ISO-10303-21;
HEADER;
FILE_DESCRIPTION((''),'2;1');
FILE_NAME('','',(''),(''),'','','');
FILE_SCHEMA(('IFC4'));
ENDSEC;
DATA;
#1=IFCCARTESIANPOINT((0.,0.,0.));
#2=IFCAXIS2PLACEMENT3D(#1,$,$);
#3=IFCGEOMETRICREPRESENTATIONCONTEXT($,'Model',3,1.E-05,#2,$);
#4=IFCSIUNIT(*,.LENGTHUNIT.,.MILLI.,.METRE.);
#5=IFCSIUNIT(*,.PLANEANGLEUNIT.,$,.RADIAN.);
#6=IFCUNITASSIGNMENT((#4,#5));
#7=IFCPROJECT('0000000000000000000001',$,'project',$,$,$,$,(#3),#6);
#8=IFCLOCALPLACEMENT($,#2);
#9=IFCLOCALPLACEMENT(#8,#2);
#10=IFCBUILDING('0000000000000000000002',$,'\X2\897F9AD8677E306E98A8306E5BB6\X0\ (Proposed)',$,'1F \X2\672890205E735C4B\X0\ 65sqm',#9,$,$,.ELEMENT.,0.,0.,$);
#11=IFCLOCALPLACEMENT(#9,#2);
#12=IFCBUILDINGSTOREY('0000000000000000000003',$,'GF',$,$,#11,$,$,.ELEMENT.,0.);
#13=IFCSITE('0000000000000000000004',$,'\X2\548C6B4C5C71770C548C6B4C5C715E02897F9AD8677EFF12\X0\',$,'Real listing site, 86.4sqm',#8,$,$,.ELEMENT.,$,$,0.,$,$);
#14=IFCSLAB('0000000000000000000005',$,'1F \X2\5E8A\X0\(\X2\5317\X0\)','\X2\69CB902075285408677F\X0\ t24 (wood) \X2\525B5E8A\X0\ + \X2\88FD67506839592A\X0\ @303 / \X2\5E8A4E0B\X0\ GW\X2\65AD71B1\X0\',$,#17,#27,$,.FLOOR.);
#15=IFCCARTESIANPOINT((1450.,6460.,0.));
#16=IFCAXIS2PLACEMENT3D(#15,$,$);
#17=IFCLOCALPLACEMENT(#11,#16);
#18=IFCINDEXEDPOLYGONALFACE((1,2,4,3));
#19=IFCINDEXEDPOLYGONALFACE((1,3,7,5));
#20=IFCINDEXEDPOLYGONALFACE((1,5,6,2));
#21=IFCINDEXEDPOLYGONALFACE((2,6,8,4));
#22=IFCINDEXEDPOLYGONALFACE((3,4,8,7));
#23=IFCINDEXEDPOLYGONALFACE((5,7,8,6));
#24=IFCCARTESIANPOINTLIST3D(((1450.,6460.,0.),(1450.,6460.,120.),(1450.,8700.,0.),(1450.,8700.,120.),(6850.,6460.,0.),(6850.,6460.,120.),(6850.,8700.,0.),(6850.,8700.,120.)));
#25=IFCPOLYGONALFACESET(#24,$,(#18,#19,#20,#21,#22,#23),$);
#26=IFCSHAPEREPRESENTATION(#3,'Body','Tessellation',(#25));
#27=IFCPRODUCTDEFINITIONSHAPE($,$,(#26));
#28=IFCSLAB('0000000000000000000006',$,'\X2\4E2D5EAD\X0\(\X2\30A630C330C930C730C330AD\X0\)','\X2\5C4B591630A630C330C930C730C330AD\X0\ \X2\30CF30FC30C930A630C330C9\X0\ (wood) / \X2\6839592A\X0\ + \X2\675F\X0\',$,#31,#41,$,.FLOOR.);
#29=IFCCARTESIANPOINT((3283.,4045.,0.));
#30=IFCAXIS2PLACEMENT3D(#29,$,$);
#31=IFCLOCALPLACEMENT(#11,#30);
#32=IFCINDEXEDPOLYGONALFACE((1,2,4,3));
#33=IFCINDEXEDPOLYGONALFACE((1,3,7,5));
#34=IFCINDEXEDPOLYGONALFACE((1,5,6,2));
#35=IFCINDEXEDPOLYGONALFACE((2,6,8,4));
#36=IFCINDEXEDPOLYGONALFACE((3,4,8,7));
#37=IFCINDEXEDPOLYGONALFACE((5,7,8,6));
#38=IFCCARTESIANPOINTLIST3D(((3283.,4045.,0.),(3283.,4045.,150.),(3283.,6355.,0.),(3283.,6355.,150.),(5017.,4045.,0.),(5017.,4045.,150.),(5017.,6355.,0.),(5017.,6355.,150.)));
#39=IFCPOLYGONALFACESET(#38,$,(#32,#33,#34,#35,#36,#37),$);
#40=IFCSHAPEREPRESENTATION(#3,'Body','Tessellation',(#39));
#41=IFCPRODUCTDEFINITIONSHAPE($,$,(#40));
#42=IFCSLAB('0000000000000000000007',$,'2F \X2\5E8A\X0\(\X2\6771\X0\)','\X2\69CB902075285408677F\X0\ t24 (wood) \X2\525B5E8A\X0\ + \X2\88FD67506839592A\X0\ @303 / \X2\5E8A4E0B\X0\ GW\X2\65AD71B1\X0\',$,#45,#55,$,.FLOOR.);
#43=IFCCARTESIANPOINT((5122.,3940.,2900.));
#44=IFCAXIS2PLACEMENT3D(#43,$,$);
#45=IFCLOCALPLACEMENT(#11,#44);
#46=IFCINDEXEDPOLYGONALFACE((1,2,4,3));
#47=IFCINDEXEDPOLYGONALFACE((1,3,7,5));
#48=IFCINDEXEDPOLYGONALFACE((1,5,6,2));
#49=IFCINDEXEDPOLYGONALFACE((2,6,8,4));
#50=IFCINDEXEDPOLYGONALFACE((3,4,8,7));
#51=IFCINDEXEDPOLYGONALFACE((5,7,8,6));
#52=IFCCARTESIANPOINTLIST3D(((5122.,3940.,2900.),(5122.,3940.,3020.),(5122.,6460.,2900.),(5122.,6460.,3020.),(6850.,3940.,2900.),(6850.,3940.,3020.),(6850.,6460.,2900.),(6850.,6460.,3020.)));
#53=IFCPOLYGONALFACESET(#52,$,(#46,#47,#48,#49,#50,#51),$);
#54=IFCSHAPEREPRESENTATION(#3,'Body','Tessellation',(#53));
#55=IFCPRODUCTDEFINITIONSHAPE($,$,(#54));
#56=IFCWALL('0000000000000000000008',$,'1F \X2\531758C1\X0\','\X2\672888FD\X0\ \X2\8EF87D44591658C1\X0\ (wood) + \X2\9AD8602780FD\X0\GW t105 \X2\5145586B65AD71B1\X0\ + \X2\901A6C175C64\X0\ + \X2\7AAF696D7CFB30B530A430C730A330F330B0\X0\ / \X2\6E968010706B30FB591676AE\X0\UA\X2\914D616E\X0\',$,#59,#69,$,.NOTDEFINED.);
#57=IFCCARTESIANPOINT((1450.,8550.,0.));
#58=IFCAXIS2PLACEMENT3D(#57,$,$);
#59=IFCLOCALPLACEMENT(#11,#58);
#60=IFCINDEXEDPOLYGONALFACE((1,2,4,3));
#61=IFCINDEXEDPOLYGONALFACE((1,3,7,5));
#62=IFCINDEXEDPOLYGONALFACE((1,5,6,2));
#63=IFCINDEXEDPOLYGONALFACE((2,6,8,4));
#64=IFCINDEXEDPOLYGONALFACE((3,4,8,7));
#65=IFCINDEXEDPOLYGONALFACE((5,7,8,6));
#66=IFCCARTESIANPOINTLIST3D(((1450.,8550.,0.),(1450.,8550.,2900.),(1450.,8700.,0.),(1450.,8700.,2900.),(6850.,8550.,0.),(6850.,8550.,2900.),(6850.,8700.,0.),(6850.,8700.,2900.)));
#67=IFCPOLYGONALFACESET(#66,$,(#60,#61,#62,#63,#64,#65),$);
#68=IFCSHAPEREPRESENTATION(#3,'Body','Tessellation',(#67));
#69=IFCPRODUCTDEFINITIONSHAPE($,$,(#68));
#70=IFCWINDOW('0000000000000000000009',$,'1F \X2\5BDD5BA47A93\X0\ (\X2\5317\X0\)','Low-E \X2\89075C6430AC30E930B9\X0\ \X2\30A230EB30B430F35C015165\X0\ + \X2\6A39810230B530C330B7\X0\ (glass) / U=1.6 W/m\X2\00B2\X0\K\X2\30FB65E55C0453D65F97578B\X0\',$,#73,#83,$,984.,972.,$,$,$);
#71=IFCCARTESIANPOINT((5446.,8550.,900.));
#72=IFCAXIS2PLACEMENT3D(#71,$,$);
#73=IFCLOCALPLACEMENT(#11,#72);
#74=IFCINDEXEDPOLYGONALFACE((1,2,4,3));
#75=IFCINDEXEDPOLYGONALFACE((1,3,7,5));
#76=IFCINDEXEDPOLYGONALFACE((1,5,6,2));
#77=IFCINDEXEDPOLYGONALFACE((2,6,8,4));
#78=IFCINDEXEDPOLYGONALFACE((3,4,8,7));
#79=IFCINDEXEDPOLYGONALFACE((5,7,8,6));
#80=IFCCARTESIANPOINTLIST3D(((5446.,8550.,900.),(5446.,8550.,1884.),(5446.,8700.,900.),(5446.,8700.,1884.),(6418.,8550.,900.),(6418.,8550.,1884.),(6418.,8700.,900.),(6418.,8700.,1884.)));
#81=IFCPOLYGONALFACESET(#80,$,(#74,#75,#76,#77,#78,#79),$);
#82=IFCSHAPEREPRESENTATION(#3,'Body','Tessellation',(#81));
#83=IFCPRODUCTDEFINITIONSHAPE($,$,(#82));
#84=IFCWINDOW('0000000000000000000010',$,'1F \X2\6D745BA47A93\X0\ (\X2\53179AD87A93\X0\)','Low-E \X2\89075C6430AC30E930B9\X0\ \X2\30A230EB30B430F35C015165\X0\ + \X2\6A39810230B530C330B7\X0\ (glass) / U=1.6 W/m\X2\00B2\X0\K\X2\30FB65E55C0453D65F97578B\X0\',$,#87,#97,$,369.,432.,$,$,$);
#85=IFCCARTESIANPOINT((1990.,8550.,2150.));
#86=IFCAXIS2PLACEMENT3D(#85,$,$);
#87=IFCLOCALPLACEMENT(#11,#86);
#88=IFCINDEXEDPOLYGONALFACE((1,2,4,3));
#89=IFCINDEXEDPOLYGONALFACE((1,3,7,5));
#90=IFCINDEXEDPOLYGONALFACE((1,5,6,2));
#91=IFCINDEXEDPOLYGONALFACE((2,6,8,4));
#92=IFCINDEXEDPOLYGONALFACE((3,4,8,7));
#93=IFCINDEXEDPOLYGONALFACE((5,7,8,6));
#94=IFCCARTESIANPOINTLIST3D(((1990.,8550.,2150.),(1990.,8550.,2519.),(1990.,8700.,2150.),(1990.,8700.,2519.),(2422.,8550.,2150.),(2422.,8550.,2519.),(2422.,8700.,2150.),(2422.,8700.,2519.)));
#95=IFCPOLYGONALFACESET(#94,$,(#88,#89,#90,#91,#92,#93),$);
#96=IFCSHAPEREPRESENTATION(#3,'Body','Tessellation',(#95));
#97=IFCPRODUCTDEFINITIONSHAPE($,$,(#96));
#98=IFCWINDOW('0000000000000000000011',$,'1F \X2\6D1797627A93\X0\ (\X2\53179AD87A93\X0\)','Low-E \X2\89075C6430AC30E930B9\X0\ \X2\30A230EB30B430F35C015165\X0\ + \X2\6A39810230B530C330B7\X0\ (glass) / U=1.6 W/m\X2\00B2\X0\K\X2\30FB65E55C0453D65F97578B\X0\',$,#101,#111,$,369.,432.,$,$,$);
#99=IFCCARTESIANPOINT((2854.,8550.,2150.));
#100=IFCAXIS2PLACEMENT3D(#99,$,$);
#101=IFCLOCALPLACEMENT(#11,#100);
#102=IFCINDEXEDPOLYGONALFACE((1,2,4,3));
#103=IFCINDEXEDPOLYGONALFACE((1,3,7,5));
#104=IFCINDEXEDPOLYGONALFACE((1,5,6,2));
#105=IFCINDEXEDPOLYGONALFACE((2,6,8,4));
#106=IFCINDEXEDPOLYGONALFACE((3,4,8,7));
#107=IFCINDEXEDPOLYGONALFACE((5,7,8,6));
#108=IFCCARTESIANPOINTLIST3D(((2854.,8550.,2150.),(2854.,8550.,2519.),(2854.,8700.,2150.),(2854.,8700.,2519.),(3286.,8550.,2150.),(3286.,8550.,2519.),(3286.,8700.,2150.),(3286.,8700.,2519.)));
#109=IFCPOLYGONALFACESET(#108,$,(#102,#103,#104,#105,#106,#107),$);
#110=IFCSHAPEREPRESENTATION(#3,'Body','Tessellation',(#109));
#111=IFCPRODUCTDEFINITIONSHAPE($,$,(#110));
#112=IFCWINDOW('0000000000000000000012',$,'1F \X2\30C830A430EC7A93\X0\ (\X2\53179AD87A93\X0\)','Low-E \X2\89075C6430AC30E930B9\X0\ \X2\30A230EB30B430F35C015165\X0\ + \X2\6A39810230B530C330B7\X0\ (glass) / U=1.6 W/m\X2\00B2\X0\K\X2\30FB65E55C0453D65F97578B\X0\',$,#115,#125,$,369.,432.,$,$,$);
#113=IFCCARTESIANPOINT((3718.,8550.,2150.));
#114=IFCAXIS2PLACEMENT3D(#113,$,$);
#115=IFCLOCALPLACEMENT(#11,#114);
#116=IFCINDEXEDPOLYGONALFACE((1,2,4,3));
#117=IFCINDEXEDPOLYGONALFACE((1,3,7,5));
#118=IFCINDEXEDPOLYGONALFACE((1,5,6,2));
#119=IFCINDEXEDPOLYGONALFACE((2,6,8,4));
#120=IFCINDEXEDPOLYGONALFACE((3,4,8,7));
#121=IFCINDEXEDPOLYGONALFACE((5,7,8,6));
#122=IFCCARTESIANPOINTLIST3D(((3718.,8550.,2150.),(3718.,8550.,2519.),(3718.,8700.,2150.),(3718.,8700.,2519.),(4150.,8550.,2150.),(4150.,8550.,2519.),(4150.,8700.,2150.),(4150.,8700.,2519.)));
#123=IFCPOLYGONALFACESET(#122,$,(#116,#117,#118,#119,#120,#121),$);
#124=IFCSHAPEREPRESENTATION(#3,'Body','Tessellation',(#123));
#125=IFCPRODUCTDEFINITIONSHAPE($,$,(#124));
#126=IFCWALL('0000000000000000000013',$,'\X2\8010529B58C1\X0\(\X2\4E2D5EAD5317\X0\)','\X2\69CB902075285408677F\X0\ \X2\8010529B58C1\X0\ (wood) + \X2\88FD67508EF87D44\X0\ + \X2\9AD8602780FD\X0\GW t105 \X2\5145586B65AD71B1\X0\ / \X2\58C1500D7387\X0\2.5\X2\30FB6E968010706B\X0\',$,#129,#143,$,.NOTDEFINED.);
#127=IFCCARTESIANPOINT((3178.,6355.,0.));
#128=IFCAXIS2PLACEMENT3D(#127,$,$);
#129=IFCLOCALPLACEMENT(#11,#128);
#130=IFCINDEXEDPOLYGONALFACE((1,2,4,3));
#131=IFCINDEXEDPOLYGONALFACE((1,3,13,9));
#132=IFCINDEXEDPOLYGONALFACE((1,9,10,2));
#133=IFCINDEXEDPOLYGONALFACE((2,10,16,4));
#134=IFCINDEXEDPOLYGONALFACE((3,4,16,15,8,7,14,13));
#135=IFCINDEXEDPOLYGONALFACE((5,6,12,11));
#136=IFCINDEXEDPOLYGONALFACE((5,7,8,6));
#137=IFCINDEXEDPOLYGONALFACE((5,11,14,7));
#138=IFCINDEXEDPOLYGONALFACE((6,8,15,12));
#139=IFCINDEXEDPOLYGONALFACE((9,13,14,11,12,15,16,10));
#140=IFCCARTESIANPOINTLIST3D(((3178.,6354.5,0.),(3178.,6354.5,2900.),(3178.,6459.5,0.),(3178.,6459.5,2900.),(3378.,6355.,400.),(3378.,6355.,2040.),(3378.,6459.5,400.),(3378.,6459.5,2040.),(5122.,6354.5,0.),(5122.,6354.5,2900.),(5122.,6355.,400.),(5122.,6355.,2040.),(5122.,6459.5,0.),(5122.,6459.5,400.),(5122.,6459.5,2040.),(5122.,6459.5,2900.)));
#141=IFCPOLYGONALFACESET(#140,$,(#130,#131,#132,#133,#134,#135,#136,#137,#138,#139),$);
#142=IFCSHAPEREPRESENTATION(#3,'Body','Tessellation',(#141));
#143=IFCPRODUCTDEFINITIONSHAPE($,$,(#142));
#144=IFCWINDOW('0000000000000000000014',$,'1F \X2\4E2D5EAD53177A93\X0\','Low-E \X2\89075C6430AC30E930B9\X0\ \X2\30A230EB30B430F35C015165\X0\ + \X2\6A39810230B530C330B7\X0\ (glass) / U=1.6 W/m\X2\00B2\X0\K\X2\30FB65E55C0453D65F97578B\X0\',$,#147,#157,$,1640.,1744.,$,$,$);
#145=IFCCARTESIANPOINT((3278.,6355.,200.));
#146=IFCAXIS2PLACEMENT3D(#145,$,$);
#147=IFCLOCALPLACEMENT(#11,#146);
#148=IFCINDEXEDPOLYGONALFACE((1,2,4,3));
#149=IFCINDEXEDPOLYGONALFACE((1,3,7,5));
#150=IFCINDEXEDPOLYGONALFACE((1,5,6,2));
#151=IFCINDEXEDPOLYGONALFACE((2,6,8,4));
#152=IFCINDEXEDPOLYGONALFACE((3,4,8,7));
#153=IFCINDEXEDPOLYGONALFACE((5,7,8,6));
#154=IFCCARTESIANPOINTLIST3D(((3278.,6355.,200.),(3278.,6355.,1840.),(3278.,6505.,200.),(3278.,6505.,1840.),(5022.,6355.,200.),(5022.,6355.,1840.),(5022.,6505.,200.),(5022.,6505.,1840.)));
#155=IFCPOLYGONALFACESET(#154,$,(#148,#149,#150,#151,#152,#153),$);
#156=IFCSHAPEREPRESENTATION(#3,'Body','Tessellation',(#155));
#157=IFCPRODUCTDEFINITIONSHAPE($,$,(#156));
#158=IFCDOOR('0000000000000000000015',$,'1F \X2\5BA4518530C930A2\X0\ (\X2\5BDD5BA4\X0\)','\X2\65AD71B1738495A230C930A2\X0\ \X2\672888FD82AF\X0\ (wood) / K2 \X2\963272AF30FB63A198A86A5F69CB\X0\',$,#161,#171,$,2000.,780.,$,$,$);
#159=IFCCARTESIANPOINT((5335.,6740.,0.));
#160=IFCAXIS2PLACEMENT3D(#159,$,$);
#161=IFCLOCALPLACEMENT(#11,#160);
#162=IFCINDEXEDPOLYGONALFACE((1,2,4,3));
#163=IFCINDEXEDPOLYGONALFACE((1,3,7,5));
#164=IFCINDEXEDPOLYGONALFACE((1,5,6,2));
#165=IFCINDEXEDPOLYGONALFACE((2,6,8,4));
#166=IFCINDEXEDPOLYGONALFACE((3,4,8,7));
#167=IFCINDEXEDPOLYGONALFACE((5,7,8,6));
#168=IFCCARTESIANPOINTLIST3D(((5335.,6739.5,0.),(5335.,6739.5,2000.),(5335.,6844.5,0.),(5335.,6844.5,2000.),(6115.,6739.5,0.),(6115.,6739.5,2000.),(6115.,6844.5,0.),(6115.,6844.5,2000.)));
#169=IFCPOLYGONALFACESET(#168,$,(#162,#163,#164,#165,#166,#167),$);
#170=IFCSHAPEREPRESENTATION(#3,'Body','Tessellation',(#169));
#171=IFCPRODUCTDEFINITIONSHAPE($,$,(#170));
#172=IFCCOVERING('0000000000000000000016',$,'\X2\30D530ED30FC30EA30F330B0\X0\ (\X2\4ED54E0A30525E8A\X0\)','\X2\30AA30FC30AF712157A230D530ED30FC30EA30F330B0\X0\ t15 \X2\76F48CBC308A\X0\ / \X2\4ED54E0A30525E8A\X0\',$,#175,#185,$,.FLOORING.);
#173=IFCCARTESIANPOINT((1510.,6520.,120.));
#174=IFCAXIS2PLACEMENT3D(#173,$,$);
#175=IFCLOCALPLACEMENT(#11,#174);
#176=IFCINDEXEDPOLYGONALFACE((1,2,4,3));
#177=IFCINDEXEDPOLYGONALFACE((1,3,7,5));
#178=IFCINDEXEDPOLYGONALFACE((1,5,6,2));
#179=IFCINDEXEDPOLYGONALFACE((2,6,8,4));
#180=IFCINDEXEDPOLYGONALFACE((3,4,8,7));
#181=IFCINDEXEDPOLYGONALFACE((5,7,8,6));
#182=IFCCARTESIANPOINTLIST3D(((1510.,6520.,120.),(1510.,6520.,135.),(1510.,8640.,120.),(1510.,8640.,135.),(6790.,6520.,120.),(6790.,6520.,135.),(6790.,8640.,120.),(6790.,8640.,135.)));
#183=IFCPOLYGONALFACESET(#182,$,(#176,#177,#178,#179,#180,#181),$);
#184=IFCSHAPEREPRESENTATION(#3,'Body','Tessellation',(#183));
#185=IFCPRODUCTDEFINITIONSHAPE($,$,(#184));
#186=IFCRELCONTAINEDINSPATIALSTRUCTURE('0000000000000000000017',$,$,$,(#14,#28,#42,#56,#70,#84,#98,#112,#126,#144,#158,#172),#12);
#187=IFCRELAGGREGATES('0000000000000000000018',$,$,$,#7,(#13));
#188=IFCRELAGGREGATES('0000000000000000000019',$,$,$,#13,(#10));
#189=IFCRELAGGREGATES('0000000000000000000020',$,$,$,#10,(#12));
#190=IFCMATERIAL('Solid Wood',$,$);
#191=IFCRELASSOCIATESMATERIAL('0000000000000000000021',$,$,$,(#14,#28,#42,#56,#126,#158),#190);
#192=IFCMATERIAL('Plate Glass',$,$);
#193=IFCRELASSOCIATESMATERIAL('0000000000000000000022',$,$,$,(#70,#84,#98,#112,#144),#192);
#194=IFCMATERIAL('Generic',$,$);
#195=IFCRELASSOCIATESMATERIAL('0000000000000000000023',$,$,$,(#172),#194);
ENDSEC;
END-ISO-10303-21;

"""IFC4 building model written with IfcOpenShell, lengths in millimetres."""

from ifc_helpers import new_model, si_unit, frame, frame_2d, origin, place, context, project, spatial, rectangle, extrude, material, element, fill, save


model = new_model("IFC4")

# Units and contexts
model_context = context("Model", 3, precision=1e-05, world=origin())
ifc_project = project(units=[si_unit("LENGTHUNIT", "METRE", prefix="MILLI"), si_unit("PLANEANGLEUNIT", "RADIAN")], contexts=[model_context])

# Site, building, storey
site_placement = place(None, origin())
site = spatial("IfcSite", under=ifc_project, at=site_placement, Name="和歌山県和歌山市西高松２", ObjectType="Real listing site, 86.4sqm", CompositionType="ELEMENT", RefElevation=0.0)
building_placement = place(site_placement, origin())
building = spatial("IfcBuilding", under=site, at=building_placement, Name="西高松の風の家 (Proposed)", ObjectType="1F 木造平屋 65sqm", CompositionType="ELEMENT", ElevationOfRefHeight=0.0, ElevationOfTerrain=0.0)
storey_placement = place(building_placement, origin())
storey = spatial("IfcBuildingStorey", under=building, at=storey_placement, Name="GF", CompositionType="ELEMENT", Elevation=0.0)

# Slabs
ifc_material_1 = material(Name="Solid Wood")
slab_1_placement = place(storey_placement, frame((1450.0, 6460.0, 0.0)))
element("IfcSlab", 1, at=slab_1_placement, inside=storey, material=ifc_material_1, Name="1F 床(北)", Description="構造用合板 t24 (wood) 剛床 + 製材根太 @303 / 床下 GW断熱", PredefinedType="FLOOR", context=model_context, shape_type="SweptSolid", body=[
    extrude(rectangle(XDim=5400.0, YDim=2240.0, at=frame_2d((2700.0, 1120.0))), frame((1450.0, 6460.0, 0.0)), (0.0, 0.0, 1.0), 120.0),
])
slab_2_placement = place(storey_placement, frame((3283.0, 4045.0, 0.0)))
element("IfcSlab", 2, at=slab_2_placement, inside=storey, material=ifc_material_1, Name="中庭(ウッドデッキ)", Description="屋外ウッドデッキ ハードウッド (wood) / 根太 + 束", PredefinedType="FLOOR", context=model_context, shape_type="SweptSolid", body=[
    extrude(rectangle(XDim=1734.0, YDim=2310.0, at=frame_2d((867.0, 1155.0))), frame((3283.0, 4045.0, 0.0)), (0.0, 0.0, 1.0), 150.0),
])
slab_3_placement = place(storey_placement, frame((5122.0, 3940.0, 2900.0)))
element("IfcSlab", 3, at=slab_3_placement, inside=storey, material=ifc_material_1, Name="2F 床(東)", Description="構造用合板 t24 (wood) 剛床 + 製材根太 @303 / 床下 GW断熱", PredefinedType="FLOOR", context=model_context, shape_type="SweptSolid", body=[
    extrude(rectangle(XDim=1728.0, YDim=2520.0, at=frame_2d((864.0, 1260.0))), frame((5122.0, 3940.0, 2900.0)), (0.0, 0.0, 1.0), 120.0),
])

# Wall, openings, windows
wall_1_placement = place(storey_placement, frame((1450.0, 8550.0, 0.0)))
wall_1 = element("IfcWall", 4, at=wall_1_placement, inside=storey, material=ifc_material_1, Name="1F 北壁", Description="木製 軸組外壁 (wood) + 高性能GW t105 充填断熱 + 通気層 + 窯業系サイディング / 準耐火・外皮UA配慮", PredefinedType="NOTDEFINED", context=model_context, shape_type="SweptSolid", body=[
    extrude(rectangle(XDim=5400.0, YDim=150.0, at=frame_2d((2700.0, 75.0))), frame((1450.0, 8550.0, 0.0)), (0.0, 0.0, 1.0), 2900.0),
])
opening_1_placement = place(storey_placement, frame((5446.0, 8550.0, 900.0)))
opening_1 = element("IfcOpeningElement", 5, at=opening_1_placement, cuts=wall_1, PredefinedType="NOTDEFINED", context=model_context, shape_type="SweptSolid", body=[
    extrude(rectangle(XDim=972.0, YDim=150.0, at=frame_2d((486.0, 75.0))), frame((5446.0, 8550.0, 900.0)), (0.0, 0.0, 1.0), 984.0),
])
opening_2_placement = place(storey_placement, frame((1990.0, 8550.0, 2150.0)))
opening_2 = element("IfcOpeningElement", 6, at=opening_2_placement, cuts=wall_1, PredefinedType="NOTDEFINED", context=model_context, shape_type="SweptSolid", body=[
    extrude(rectangle(XDim=432.0, YDim=150.0, at=frame_2d((216.0, 75.0))), frame((1990.0, 8550.0, 2150.0)), (0.0, 0.0, 1.0), 369.0),
])
opening_3_placement = place(storey_placement, frame((2854.0, 8550.0, 2150.0)))
opening_3 = element("IfcOpeningElement", 7, at=opening_3_placement, cuts=wall_1, PredefinedType="NOTDEFINED", context=model_context, shape_type="SweptSolid", body=[
    extrude(rectangle(XDim=432.0, YDim=150.0, at=frame_2d((216.0, 75.0))), frame((2854.0, 8550.0, 2150.0)), (0.0, 0.0, 1.0), 369.0),
])
opening_4_placement = place(storey_placement, frame((3718.0, 8550.0, 2150.0)))
opening_4 = element("IfcOpeningElement", 8, at=opening_4_placement, cuts=wall_1, PredefinedType="NOTDEFINED", context=model_context, shape_type="SweptSolid", body=[
    extrude(rectangle(XDim=432.0, YDim=150.0, at=frame_2d((216.0, 75.0))), frame((3718.0, 8550.0, 2150.0)), (0.0, 0.0, 1.0), 369.0),
])
ifc_material_2 = material(Name="Plate Glass")
window_1_placement = place(storey_placement, frame((5446.0, 8550.0, 900.0)))
window_1 = element("IfcWindow", 9, at=window_1_placement, inside=storey, material=ifc_material_2, Name="1F 寝室窓 (北)", Description="Low-E 複層ガラス アルゴン封入 + 樹脂サッシ (glass) / U=1.6 W/m²K・日射取得型", OverallHeight=984.0, OverallWidth=972.0, context=model_context, shape_type="SweptSolid", body=[
    extrude(rectangle(XDim=972.0, YDim=150.0, at=frame_2d((486.0, 75.0))), frame((5446.0, 8550.0, 900.0)), (0.0, 0.0, 1.0), 984.0),
])
fill(opening_1, window_1)
window_2_placement = place(storey_placement, frame((1990.0, 8550.0, 2150.0)))
window_2 = element("IfcWindow", 10, at=window_2_placement, inside=storey, material=ifc_material_2, Name="1F 浴室窓 (北高窓)", Description="Low-E 複層ガラス アルゴン封入 + 樹脂サッシ (glass) / U=1.6 W/m²K・日射取得型", OverallHeight=369.0, OverallWidth=432.0, context=model_context, shape_type="SweptSolid", body=[
    extrude(rectangle(XDim=432.0, YDim=150.0, at=frame_2d((216.0, 75.0))), frame((1990.0, 8550.0, 2150.0)), (0.0, 0.0, 1.0), 369.0),
])
fill(opening_2, window_2)
window_3_placement = place(storey_placement, frame((2854.0, 8550.0, 2150.0)))
window_3 = element("IfcWindow", 11, at=window_3_placement, inside=storey, material=ifc_material_2, Name="1F 洗面窓 (北高窓)", Description="Low-E 複層ガラス アルゴン封入 + 樹脂サッシ (glass) / U=1.6 W/m²K・日射取得型", OverallHeight=369.0, OverallWidth=432.0, context=model_context, shape_type="SweptSolid", body=[
    extrude(rectangle(XDim=432.0, YDim=150.0, at=frame_2d((216.0, 75.0))), frame((2854.0, 8550.0, 2150.0)), (0.0, 0.0, 1.0), 369.0),
])
fill(opening_3, window_3)
window_4_placement = place(storey_placement, frame((3718.0, 8550.0, 2150.0)))
window_4 = element("IfcWindow", 12, at=window_4_placement, inside=storey, material=ifc_material_2, Name="1F トイレ窓 (北高窓)", Description="Low-E 複層ガラス アルゴン封入 + 樹脂サッシ (glass) / U=1.6 W/m²K・日射取得型", OverallHeight=369.0, OverallWidth=432.0, context=model_context, shape_type="SweptSolid", body=[
    extrude(rectangle(XDim=432.0, YDim=150.0, at=frame_2d((216.0, 75.0))), frame((3718.0, 8550.0, 2150.0)), (0.0, 0.0, 1.0), 369.0),
])
fill(opening_4, window_4)

# Wall, opening, window
wall_2_placement = place(storey_placement, frame((3178.0, 6355.0, 0.0)))
wall_2 = element("IfcWall", 13, at=wall_2_placement, inside=storey, material=ifc_material_1, Name="耐力壁(中庭北)", Description="構造用合板 耐力壁 (wood) + 製材軸組 + 高性能GW t105 充填断熱 / 壁倍率2.5・準耐火", PredefinedType="NOTDEFINED", context=model_context, shape_type="SweptSolid", body=[
    extrude(rectangle(XDim=1944.0, YDim=105.0, at=frame_2d((972.0, 52.0))), frame((3178.0, 6355.0, 0.0)), (0.0, 0.0, 1.0), 2900.0),
])
opening_5_placement = place(storey_placement, frame((3278.0, 6355.0, 200.0)))
opening_5 = element("IfcOpeningElement", 14, at=opening_5_placement, cuts=wall_2, PredefinedType="NOTDEFINED", context=model_context, shape_type="SweptSolid", body=[
    extrude(rectangle(XDim=1744.0, YDim=150.0, at=frame_2d((872.0, 75.0))), frame((3278.0, 6355.0, 200.0)), (0.0, 0.0, 1.0), 1640.0),
])
window_5_placement = place(storey_placement, frame((3278.0, 6355.0, 200.0)))
window_5 = element("IfcWindow", 15, at=window_5_placement, inside=storey, material=ifc_material_2, Name="1F 中庭北窓", Description="Low-E 複層ガラス アルゴン封入 + 樹脂サッシ (glass) / U=1.6 W/m²K・日射取得型", OverallHeight=1640.0, OverallWidth=1744.0, context=model_context, shape_type="SweptSolid", body=[
    extrude(rectangle(XDim=1744.0, YDim=150.0, at=frame_2d((872.0, 75.0))), frame((3278.0, 6355.0, 200.0)), (0.0, 0.0, 1.0), 1640.0),
])
fill(opening_5, window_5)

# Door
door_1_placement = place(storey_placement, frame((5335.0, 6740.0, 0.0)))
element("IfcDoor", 16, at=door_1_placement, inside=storey, material=ifc_material_1, Name="1F 室内ドア (寝室)", Description="断熱玄関ドア 木製芯 (wood) / K2 防犯・採風機構", OverallHeight=2000.0, OverallWidth=780.0, context=model_context, shape_type="SweptSolid", body=[
    extrude(rectangle(XDim=780.0, YDim=105.0, at=frame_2d((390.0, 52.0))), frame((5335.0, 6740.0, 0.0)), (0.0, 0.0, 1.0), 2000.0),
])

# Covering
ifc_material_3 = material(Name="Generic")
covering_1_placement = place(storey_placement, frame((1510.0, 6520.0, 120.0)))
element("IfcCovering", 17, at=covering_1_placement, inside=storey, material=ifc_material_3, Name="フローリング (仕上げ床)", Description="オーク無垢フローリング t15 直貼り / 仕上げ床", PredefinedType="FLOORING", context=model_context, shape_type="SweptSolid", body=[
    extrude(rectangle(XDim=5280.0, YDim=2120.0, at=frame_2d((2640.0, 1060.0))), frame((1510.0, 6520.0, 120.0)), (0.0, 0.0, 1.0), 15.0),
])

save(model, "model.ifc")
